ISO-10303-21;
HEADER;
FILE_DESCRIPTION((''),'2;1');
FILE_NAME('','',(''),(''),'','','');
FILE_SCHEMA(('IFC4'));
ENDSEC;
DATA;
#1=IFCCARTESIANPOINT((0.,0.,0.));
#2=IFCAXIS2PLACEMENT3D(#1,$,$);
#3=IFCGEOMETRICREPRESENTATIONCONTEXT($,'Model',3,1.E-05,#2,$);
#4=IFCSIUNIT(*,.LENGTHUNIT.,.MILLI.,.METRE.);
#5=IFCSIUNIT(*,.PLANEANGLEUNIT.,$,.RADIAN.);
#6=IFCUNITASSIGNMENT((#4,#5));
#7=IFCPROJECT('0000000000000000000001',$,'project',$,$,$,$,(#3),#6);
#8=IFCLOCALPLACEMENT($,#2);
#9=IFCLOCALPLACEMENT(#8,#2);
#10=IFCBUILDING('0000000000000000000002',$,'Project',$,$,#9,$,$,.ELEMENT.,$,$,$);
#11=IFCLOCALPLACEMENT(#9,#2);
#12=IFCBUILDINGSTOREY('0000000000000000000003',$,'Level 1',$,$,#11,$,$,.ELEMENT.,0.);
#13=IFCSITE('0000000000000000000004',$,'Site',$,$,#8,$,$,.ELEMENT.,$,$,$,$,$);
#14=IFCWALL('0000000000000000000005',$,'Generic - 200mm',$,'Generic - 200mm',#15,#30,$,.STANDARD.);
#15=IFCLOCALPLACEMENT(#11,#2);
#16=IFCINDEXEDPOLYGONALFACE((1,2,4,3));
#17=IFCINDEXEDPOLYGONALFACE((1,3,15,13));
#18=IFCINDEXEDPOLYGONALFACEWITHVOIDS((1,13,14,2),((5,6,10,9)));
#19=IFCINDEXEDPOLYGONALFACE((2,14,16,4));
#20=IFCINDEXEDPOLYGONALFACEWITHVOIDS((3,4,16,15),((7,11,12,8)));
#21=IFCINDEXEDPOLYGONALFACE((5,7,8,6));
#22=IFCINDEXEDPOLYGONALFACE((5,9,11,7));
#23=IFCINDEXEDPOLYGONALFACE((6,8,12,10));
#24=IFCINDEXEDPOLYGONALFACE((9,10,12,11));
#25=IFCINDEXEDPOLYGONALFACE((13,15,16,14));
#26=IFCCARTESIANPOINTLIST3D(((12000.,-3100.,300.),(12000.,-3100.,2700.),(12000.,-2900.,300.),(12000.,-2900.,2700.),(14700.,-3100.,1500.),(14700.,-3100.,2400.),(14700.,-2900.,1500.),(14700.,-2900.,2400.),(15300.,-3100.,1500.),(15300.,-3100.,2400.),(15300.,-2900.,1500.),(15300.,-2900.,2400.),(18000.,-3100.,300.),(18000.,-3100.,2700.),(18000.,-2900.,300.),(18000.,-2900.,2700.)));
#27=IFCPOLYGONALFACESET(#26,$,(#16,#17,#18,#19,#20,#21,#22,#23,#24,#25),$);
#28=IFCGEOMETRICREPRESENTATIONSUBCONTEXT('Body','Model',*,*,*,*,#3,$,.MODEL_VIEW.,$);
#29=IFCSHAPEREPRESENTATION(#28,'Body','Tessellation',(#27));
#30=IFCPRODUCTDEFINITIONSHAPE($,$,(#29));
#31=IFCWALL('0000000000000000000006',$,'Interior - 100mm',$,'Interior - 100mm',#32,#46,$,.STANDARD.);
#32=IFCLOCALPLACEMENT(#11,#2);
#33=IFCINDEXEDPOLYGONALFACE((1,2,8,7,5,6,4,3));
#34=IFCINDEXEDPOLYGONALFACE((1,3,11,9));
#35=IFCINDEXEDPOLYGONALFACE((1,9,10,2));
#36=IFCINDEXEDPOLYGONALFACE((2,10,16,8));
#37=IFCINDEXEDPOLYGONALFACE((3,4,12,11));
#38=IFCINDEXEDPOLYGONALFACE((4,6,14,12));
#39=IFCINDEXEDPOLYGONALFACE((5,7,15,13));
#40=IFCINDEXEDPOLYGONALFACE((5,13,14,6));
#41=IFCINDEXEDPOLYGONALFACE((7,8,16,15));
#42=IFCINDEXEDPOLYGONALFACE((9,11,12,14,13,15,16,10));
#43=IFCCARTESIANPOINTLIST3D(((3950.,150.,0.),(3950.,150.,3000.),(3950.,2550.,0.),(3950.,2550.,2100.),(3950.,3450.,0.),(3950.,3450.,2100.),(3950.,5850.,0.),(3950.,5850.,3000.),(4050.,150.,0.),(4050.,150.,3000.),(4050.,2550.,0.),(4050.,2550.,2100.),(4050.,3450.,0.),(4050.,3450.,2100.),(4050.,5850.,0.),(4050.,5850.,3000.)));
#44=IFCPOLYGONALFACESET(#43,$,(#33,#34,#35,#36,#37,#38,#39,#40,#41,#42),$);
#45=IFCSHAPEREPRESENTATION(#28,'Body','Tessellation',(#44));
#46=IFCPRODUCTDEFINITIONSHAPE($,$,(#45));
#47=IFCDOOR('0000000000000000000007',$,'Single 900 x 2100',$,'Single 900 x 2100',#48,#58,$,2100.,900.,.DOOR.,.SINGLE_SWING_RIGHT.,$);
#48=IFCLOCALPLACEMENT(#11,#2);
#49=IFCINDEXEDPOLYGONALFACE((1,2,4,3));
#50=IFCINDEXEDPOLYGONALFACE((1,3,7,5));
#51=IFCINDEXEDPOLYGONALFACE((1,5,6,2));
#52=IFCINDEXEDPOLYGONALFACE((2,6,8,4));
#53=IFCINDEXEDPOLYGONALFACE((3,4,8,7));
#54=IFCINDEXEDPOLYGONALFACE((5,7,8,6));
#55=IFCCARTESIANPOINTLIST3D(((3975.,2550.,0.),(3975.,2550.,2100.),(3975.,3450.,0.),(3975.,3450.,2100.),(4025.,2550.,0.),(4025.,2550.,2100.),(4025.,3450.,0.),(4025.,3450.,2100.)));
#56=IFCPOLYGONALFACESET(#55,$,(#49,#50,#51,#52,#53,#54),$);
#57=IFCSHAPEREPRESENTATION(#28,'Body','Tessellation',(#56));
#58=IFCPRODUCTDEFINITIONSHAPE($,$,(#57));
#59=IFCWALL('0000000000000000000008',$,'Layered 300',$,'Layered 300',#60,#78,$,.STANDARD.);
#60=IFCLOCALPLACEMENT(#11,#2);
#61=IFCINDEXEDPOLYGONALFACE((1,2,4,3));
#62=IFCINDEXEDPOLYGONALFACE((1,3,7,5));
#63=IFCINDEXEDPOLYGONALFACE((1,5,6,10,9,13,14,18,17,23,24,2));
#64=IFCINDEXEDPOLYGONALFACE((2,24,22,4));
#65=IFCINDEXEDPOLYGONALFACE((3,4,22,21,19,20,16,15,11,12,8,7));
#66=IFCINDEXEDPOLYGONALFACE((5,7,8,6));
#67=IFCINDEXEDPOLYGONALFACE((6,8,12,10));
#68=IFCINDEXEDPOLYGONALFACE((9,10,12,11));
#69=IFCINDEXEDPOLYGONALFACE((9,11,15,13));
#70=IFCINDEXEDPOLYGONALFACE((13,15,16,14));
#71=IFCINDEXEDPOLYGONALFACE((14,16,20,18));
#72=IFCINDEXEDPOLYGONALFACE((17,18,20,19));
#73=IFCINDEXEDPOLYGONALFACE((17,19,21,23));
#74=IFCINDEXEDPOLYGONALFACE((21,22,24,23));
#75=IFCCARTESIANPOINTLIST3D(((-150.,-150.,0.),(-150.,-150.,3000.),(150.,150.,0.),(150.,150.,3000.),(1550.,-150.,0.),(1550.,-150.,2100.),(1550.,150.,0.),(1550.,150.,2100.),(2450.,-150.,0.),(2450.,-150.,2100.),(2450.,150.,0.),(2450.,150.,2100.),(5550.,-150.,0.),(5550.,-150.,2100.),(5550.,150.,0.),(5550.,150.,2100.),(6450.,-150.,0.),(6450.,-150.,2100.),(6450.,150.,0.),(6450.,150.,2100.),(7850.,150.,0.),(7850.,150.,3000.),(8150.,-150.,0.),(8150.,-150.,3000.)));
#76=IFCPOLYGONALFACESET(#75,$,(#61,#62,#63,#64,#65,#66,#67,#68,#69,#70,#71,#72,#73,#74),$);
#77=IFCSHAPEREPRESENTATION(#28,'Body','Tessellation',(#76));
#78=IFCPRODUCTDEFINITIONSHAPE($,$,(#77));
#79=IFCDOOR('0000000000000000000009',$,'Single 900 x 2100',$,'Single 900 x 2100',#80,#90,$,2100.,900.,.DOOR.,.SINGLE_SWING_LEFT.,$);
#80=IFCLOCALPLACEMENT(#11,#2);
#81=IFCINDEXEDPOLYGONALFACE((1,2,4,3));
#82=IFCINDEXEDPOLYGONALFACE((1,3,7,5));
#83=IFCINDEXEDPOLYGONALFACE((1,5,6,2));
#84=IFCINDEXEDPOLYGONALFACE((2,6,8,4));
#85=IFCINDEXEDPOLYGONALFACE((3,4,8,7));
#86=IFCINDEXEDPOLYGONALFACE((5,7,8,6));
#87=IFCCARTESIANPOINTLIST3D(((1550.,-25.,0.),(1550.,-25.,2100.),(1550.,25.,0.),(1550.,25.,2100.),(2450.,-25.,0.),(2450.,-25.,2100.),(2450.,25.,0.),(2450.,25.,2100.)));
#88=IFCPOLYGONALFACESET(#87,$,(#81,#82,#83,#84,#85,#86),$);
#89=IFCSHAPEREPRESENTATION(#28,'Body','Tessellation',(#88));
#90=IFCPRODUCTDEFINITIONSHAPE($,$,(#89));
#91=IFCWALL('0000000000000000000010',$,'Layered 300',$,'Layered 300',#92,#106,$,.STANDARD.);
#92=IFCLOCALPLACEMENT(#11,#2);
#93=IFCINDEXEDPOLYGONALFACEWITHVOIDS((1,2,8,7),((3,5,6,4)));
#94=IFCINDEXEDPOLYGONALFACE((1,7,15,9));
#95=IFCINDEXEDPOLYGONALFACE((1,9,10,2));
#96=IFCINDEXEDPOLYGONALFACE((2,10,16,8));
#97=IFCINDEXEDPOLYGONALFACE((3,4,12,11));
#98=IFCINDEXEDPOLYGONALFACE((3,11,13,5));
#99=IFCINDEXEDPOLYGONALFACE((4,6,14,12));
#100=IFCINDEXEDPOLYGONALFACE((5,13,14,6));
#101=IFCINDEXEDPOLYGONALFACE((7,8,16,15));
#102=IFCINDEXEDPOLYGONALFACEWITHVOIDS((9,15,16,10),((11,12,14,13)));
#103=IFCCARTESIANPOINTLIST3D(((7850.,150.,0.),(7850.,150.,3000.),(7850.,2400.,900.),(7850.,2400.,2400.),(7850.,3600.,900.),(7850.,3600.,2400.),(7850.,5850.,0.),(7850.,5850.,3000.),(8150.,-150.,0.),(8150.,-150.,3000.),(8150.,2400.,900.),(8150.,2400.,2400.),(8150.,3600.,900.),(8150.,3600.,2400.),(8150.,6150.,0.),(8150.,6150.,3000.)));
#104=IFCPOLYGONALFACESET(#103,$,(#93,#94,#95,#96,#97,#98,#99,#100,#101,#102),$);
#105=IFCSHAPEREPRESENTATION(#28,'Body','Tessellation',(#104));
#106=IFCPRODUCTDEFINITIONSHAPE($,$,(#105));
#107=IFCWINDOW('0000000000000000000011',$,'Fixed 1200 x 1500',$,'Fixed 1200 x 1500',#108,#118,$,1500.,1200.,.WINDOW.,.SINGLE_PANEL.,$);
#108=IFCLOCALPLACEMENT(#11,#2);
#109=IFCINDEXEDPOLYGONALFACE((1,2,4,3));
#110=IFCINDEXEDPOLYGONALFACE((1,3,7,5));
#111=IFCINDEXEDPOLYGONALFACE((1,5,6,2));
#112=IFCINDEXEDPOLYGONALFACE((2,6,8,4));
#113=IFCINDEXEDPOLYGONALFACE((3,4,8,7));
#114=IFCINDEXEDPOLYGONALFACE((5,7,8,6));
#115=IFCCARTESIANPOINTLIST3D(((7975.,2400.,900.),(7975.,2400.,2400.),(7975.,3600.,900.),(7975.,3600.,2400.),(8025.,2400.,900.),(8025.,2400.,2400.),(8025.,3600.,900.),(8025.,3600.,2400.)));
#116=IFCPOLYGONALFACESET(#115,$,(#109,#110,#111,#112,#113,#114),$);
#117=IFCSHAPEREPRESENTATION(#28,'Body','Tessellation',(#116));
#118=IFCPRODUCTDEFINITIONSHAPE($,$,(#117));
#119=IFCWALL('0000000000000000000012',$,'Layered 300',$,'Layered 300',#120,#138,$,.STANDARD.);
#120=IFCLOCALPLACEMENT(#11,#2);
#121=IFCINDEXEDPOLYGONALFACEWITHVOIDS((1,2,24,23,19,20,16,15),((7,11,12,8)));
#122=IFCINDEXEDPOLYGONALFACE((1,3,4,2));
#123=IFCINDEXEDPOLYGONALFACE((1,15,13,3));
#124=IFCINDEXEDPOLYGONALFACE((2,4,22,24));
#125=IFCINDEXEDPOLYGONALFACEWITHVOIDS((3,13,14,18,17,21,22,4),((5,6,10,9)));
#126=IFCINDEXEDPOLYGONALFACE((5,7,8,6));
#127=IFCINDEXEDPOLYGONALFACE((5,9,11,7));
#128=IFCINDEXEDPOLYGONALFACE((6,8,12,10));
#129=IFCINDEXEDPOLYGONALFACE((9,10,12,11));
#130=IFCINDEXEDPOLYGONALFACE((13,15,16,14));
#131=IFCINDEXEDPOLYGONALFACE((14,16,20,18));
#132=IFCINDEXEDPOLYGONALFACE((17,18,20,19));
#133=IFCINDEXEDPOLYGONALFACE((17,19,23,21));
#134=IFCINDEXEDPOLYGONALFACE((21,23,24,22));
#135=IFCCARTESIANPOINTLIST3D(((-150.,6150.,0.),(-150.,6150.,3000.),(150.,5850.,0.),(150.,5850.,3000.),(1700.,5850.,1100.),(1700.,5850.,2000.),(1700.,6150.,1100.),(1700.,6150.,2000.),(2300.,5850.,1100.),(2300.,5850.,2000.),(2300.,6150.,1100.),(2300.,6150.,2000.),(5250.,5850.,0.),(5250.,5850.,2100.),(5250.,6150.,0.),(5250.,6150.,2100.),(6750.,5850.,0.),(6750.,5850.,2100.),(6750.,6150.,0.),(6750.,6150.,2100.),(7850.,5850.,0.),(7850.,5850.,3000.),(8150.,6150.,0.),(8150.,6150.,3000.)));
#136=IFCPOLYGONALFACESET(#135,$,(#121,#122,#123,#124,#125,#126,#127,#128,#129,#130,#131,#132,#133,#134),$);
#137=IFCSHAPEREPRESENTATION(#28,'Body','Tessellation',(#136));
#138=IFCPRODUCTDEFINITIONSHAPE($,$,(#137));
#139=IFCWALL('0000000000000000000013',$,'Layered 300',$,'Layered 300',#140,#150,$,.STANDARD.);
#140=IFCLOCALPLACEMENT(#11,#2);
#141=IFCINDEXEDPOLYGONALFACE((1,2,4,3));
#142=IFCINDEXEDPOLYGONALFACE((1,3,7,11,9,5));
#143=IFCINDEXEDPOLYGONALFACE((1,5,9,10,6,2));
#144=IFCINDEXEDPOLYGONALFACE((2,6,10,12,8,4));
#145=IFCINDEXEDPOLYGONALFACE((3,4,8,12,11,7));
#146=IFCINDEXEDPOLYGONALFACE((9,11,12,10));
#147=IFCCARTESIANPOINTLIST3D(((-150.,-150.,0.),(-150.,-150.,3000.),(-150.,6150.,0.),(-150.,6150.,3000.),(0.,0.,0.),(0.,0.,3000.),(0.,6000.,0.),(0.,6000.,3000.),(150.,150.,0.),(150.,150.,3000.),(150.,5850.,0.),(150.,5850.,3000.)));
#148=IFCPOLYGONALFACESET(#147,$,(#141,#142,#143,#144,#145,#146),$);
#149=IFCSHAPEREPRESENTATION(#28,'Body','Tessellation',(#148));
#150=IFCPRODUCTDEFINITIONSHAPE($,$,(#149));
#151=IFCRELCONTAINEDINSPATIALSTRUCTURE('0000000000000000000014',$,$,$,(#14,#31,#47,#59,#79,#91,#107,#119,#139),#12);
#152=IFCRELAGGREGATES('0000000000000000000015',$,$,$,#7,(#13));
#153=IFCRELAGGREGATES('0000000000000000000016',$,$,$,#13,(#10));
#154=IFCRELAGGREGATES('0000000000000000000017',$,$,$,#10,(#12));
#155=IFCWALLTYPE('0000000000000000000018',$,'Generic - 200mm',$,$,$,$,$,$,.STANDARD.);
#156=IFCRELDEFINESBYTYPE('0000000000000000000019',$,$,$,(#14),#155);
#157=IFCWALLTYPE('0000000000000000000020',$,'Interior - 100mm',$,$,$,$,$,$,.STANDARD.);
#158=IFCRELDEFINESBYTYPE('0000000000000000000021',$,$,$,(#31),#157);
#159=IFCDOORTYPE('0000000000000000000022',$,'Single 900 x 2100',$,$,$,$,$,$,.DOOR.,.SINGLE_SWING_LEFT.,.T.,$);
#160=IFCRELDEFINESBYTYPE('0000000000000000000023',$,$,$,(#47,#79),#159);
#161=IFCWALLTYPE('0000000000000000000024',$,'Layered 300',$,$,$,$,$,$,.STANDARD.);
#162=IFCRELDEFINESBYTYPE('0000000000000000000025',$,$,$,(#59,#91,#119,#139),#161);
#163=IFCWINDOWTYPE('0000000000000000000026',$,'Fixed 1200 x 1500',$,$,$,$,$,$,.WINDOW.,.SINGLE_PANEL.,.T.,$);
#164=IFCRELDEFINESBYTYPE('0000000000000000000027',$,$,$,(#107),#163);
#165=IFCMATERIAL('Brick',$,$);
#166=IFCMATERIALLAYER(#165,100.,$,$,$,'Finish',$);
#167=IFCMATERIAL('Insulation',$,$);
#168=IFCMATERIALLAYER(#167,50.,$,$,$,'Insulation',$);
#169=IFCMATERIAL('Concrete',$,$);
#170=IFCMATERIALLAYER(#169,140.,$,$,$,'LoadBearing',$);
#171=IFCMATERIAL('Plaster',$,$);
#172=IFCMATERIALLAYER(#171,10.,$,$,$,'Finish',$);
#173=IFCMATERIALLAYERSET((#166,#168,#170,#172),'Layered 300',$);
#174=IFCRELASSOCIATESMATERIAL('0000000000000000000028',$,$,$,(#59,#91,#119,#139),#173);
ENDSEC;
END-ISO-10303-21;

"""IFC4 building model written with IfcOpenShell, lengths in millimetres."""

from ifc_helpers import new_model, si_unit, frame, frame_2d, origin, origin_with_axes, place, context, subcontext, project, spatial, polyline, rectangle, outline, extrude, material, layer, layer_set, layer_usage, type_object, element, fill, save


model = new_model("IFC4")

# Units and contexts
model_context = context("Model", 3, precision=1e-05, world=origin())
body_context = subcontext(model_context, "Body", "Model", "MODEL_VIEW")
ifc_project = project(units=[si_unit("LENGTHUNIT", "METRE", prefix="MILLI"), si_unit("PLANEANGLEUNIT", "RADIAN")], contexts=[model_context])

# Site, building, storey
site_placement = place(None, origin())
site = spatial("IfcSite", under=ifc_project, at=site_placement, Name="Site", CompositionType="ELEMENT")
building_placement = place(site_placement, origin())
building = spatial("IfcBuilding", under=site, at=building_placement, Name="Project", CompositionType="ELEMENT")
storey_placement = place(building_placement, origin())
storey = spatial("IfcBuildingStorey", under=building, at=storey_placement, Name="Level 1", CompositionType="ELEMENT", Elevation=0.0)

# Wall, opening
wall_type_1 = type_object("IfcWallType", Name="Generic - 200mm", PredefinedType="STANDARD")
wall_1_placement = place(storey_placement, frame((12000.0, -3000.0, 300.0), z_axis=(0.0, 0.0, 1.0), x_axis=(1.0, 0.0, 0.0)))
wall_1 = element("IfcWall", 1, at=wall_1_placement, inside=storey, type_object=wall_type_1, Name="Generic - 200mm", ObjectType="Generic - 200mm", PredefinedType="STANDARD", context=body_context, shape_type="SweptSolid", body=[
    extrude(outline(polyline([(0.0, -100.0), (0.0, 100.0), (6000.0, 100.0), (6000.0, -100.0), (0.0, -100.0)])), origin(), (0.0, 0.0, 1.0), 2400.0),
])
opening_1_placement = place(wall_1_placement, frame((2700.0, 0.0, 1200.0), z_axis=(0.0, 0.0, 1.0), x_axis=(1.0, 0.0, 0.0)))
element("IfcOpeningElement", 2, at=opening_1_placement, cuts=wall_1, PredefinedType="OPENING", context=body_context, shape_type="SweptSolid", body=[
    extrude(rectangle(XDim=600.0, YDim=220.0, at=frame_2d((300.0, 0.0))), origin(), (0.0, 0.0, 1.0), 900.0),
])

# Wall, opening, door
wall_type_2 = type_object("IfcWallType", Name="Interior - 100mm", PredefinedType="STANDARD")
wall_2_placement = place(storey_placement, frame((4000.0, 0.0, 0.0), z_axis=(0.0, 0.0, 1.0), x_axis=(0.0, 1.0, 0.0)))
wall_2 = element("IfcWall", 3, at=wall_2_placement, inside=storey, type_object=wall_type_2, Name="Interior - 100mm", ObjectType="Interior - 100mm", PredefinedType="STANDARD", context=body_context, shape_type="SweptSolid", body=[
    extrude(outline(polyline([(150.0, -50.0), (150.0, 50.0), (5850.0, 50.0), (5850.0, -50.0), (150.0, -50.0)])), origin(), (0.0, 0.0, 1.0), 3000.0),
])
opening_2_placement = place(wall_2_placement, frame((2550.0, 0.0, 0.0), z_axis=(0.0, 0.0, 1.0), x_axis=(1.0, 0.0, 0.0)))
opening_2 = element("IfcOpeningElement", 4, at=opening_2_placement, cuts=wall_2, PredefinedType="OPENING", context=body_context, shape_type="SweptSolid", body=[
    extrude(rectangle(XDim=900.0, YDim=120.0, at=frame_2d((450.0, 0.0))), origin(), (0.0, 0.0, 1.0), 2100.0),
])
door_type = type_object("IfcDoorType", Name="Single 900 x 2100", OperationType="SINGLE_SWING_LEFT", ParameterTakesPrecedence=True, PredefinedType="DOOR")
door_1_placement = place(opening_2_placement, origin())
door_1 = element("IfcDoor", 5, at=door_1_placement, inside=storey, type_object=door_type, Name="Single 900 x 2100", ObjectType="Single 900 x 2100", OperationType="SINGLE_SWING_RIGHT", OverallHeight=2100.0, OverallWidth=900.0, PredefinedType="DOOR", context=body_context, shape_type="SweptSolid", body=[
    extrude(rectangle(XDim=900.0, YDim=50.0, at=frame_2d((450.0, 0.0))), origin(), (0.0, 0.0, 1.0), 2100.0),
])
fill(opening_2, door_1)

# Wall, openings, door
ifc_material_1 = material(Name="Brick")
ifc_layer_1 = layer(ifc_material_1, 100.0, Category="Finish")
ifc_material_2 = material(Name="Insulation")
ifc_layer_2 = layer(ifc_material_2, 50.0, Category="Insulation")
ifc_material_3 = material(Name="Concrete")
ifc_layer_3 = layer(ifc_material_3, 140.0, Category="LoadBearing")
ifc_material_4 = material(Name="Plaster")
ifc_layer_4 = layer(ifc_material_4, 10.0, Category="Finish")
ifc_layer_set = layer_set([ifc_layer_1, ifc_layer_2, ifc_layer_3, ifc_layer_4], Name="Layered 300")
ifc_layer_usage_1 = layer_usage(ifc_layer_set, "AXIS2", "NEGATIVE", 150.0)
wall_type_3 = type_object("IfcWallType", Name="Layered 300", PredefinedType="STANDARD")
wall_3_placement = place(storey_placement, origin_with_axes())
wall_3 = element("IfcWall", 6, at=wall_3_placement, inside=storey, type_object=wall_type_3, material=ifc_layer_usage_1, Name="Layered 300", ObjectType="Layered 300", PredefinedType="STANDARD", context=body_context, shape_type="SweptSolid", body=[
    extrude(outline(polyline([(-150.0, -150.0), (0.0, 0.0), (150.0, 150.0), (7850.0, 150.0), (8000.0, 0.0), (8150.0, -150.0), (-150.0, -150.0)])), origin(), (0.0, 0.0, 1.0), 3000.0),
])
opening_3_placement = place(wall_3_placement, frame((1550.0, 0.0, 0.0), z_axis=(0.0, 0.0, 1.0), x_axis=(1.0, 0.0, 0.0)))
opening_3 = element("IfcOpeningElement", 7, at=opening_3_placement, cuts=wall_3, PredefinedType="OPENING", context=body_context, shape_type="SweptSolid", body=[
    extrude(rectangle(XDim=900.0, YDim=320.0, at=frame_2d((450.0, 0.0))), origin(), (0.0, 0.0, 1.0), 2100.0),
])
opening_4_placement = place(wall_3_placement, frame((5550.0, 0.0, 0.0), z_axis=(0.0, 0.0, 1.0), x_axis=(1.0, 0.0, 0.0)))
element("IfcOpeningElement", 8, at=opening_4_placement, cuts=wall_3, PredefinedType="OPENING", context=body_context, shape_type="SweptSolid", body=[
    extrude(rectangle(XDim=900.0, YDim=320.0, at=frame_2d((450.0, 0.0))), origin(), (0.0, 0.0, 1.0), 2100.0),
])
door_2_placement = place(opening_3_placement, origin())
door_2 = element("IfcDoor", 9, at=door_2_placement, inside=storey, type_object=door_type, Name="Single 900 x 2100", ObjectType="Single 900 x 2100", OperationType="SINGLE_SWING_LEFT", OverallHeight=2100.0, OverallWidth=900.0, PredefinedType="DOOR", context=body_context, shape_type="SweptSolid", body=[
    extrude(rectangle(XDim=900.0, YDim=50.0, at=frame_2d((450.0, 0.0))), origin(), (0.0, 0.0, 1.0), 2100.0),
])
fill(opening_3, door_2)

# Wall, opening, window
wall_4_placement = place(storey_placement, frame((8000.0, 0.0, 0.0), z_axis=(0.0, 0.0, 1.0), x_axis=(0.0, 1.0, 0.0)))
wall_4 = element("IfcWall", 10, at=wall_4_placement, inside=storey, type_object=wall_type_3, material=ifc_layer_usage_1, Name="Layered 300", ObjectType="Layered 300", PredefinedType="STANDARD", context=body_context, shape_type="SweptSolid", body=[
    extrude(outline(polyline([(-150.0, -150.0), (0.0, 0.0), (150.0, 150.0), (5850.0, 150.0), (6000.0, 0.0), (6150.0, -150.0), (-150.0, -150.0)])), origin(), (0.0, 0.0, 1.0), 3000.0),
])
opening_5_placement = place(wall_4_placement, frame((2400.0, 0.0, 900.0), z_axis=(0.0, 0.0, 1.0), x_axis=(1.0, 0.0, 0.0)))
opening_5 = element("IfcOpeningElement", 11, at=opening_5_placement, cuts=wall_4, PredefinedType="OPENING", context=body_context, shape_type="SweptSolid", body=[
    extrude(rectangle(XDim=1200.0, YDim=320.0, at=frame_2d((600.0, 0.0))), origin(), (0.0, 0.0, 1.0), 1500.0),
])
window_type = type_object("IfcWindowType", Name="Fixed 1200 x 1500", ParameterTakesPrecedence=True, PartitioningType="SINGLE_PANEL", PredefinedType="WINDOW")
window_placement = place(opening_5_placement, origin())
window = element("IfcWindow", 12, at=window_placement, inside=storey, type_object=window_type, Name="Fixed 1200 x 1500", ObjectType="Fixed 1200 x 1500", OverallHeight=1500.0, OverallWidth=1200.0, PartitioningType="SINGLE_PANEL", PredefinedType="WINDOW", context=body_context, shape_type="SweptSolid", body=[
    extrude(rectangle(XDim=1200.0, YDim=50.0, at=frame_2d((600.0, 0.0))), origin(), (0.0, 0.0, 1.0), 1500.0),
])
fill(opening_5, window)

# Wall, openings
wall_5_placement = place(storey_placement, frame((8000.0, 6000.0, 0.0), z_axis=(0.0, 0.0, 1.0), x_axis=(-1.0, 0.0, 0.0)))
wall_5 = element("IfcWall", 13, at=wall_5_placement, inside=storey, type_object=wall_type_3, material=ifc_layer_usage_1, Name="Layered 300", ObjectType="Layered 300", PredefinedType="STANDARD", context=body_context, shape_type="SweptSolid", body=[
    extrude(outline(polyline([(-150.0, -150.0), (0.0, 0.0), (150.0, 150.0), (7850.0, 150.0), (8000.0, 0.0), (8150.0, -150.0), (-150.0, -150.0)])), origin(), (0.0, 0.0, 1.0), 3000.0),
])
opening_6_placement = place(wall_5_placement, frame((1250.0, 0.0, 0.0), z_axis=(0.0, 0.0, 1.0), x_axis=(1.0, 0.0, 0.0)))
element("IfcOpeningElement", 14, at=opening_6_placement, cuts=wall_5, PredefinedType="OPENING", context=body_context, shape_type="SweptSolid", body=[
    extrude(rectangle(XDim=1500.0, YDim=320.0, at=frame_2d((750.0, 0.0))), origin(), (0.0, 0.0, 1.0), 2100.0),
])
opening_7_placement = place(wall_5_placement, frame((5700.0, 0.0, 1100.0), z_axis=(0.0, 0.0, 1.0), x_axis=(1.0, 0.0, 0.0)))
element("IfcOpeningElement", 15, at=opening_7_placement, cuts=wall_5, PredefinedType="OPENING", context=body_context, shape_type="SweptSolid", body=[
    extrude(rectangle(XDim=600.0, YDim=320.0, at=frame_2d((300.0, 0.0))), origin(), (0.0, 0.0, 1.0), 900.0),
])

# Wall
wall_6_placement = place(storey_placement, frame((0.0, 6000.0, 0.0), z_axis=(0.0, 0.0, 1.0), x_axis=(0.0, -1.0, 0.0)))
element("IfcWall", 16, at=wall_6_placement, inside=storey, type_object=wall_type_3, material=ifc_layer_usage_1, Name="Layered 300", ObjectType="Layered 300", PredefinedType="STANDARD", context=body_context, shape_type="SweptSolid", body=[
    extrude(outline(polyline([(-150.0, -150.0), (0.0, 0.0), (150.0, 150.0), (5850.0, 150.0), (6000.0, 0.0), (6150.0, -150.0), (-150.0, -150.0)])), origin(), (0.0, 0.0, 1.0), 3000.0),
])

save(model, "model.ifc")
